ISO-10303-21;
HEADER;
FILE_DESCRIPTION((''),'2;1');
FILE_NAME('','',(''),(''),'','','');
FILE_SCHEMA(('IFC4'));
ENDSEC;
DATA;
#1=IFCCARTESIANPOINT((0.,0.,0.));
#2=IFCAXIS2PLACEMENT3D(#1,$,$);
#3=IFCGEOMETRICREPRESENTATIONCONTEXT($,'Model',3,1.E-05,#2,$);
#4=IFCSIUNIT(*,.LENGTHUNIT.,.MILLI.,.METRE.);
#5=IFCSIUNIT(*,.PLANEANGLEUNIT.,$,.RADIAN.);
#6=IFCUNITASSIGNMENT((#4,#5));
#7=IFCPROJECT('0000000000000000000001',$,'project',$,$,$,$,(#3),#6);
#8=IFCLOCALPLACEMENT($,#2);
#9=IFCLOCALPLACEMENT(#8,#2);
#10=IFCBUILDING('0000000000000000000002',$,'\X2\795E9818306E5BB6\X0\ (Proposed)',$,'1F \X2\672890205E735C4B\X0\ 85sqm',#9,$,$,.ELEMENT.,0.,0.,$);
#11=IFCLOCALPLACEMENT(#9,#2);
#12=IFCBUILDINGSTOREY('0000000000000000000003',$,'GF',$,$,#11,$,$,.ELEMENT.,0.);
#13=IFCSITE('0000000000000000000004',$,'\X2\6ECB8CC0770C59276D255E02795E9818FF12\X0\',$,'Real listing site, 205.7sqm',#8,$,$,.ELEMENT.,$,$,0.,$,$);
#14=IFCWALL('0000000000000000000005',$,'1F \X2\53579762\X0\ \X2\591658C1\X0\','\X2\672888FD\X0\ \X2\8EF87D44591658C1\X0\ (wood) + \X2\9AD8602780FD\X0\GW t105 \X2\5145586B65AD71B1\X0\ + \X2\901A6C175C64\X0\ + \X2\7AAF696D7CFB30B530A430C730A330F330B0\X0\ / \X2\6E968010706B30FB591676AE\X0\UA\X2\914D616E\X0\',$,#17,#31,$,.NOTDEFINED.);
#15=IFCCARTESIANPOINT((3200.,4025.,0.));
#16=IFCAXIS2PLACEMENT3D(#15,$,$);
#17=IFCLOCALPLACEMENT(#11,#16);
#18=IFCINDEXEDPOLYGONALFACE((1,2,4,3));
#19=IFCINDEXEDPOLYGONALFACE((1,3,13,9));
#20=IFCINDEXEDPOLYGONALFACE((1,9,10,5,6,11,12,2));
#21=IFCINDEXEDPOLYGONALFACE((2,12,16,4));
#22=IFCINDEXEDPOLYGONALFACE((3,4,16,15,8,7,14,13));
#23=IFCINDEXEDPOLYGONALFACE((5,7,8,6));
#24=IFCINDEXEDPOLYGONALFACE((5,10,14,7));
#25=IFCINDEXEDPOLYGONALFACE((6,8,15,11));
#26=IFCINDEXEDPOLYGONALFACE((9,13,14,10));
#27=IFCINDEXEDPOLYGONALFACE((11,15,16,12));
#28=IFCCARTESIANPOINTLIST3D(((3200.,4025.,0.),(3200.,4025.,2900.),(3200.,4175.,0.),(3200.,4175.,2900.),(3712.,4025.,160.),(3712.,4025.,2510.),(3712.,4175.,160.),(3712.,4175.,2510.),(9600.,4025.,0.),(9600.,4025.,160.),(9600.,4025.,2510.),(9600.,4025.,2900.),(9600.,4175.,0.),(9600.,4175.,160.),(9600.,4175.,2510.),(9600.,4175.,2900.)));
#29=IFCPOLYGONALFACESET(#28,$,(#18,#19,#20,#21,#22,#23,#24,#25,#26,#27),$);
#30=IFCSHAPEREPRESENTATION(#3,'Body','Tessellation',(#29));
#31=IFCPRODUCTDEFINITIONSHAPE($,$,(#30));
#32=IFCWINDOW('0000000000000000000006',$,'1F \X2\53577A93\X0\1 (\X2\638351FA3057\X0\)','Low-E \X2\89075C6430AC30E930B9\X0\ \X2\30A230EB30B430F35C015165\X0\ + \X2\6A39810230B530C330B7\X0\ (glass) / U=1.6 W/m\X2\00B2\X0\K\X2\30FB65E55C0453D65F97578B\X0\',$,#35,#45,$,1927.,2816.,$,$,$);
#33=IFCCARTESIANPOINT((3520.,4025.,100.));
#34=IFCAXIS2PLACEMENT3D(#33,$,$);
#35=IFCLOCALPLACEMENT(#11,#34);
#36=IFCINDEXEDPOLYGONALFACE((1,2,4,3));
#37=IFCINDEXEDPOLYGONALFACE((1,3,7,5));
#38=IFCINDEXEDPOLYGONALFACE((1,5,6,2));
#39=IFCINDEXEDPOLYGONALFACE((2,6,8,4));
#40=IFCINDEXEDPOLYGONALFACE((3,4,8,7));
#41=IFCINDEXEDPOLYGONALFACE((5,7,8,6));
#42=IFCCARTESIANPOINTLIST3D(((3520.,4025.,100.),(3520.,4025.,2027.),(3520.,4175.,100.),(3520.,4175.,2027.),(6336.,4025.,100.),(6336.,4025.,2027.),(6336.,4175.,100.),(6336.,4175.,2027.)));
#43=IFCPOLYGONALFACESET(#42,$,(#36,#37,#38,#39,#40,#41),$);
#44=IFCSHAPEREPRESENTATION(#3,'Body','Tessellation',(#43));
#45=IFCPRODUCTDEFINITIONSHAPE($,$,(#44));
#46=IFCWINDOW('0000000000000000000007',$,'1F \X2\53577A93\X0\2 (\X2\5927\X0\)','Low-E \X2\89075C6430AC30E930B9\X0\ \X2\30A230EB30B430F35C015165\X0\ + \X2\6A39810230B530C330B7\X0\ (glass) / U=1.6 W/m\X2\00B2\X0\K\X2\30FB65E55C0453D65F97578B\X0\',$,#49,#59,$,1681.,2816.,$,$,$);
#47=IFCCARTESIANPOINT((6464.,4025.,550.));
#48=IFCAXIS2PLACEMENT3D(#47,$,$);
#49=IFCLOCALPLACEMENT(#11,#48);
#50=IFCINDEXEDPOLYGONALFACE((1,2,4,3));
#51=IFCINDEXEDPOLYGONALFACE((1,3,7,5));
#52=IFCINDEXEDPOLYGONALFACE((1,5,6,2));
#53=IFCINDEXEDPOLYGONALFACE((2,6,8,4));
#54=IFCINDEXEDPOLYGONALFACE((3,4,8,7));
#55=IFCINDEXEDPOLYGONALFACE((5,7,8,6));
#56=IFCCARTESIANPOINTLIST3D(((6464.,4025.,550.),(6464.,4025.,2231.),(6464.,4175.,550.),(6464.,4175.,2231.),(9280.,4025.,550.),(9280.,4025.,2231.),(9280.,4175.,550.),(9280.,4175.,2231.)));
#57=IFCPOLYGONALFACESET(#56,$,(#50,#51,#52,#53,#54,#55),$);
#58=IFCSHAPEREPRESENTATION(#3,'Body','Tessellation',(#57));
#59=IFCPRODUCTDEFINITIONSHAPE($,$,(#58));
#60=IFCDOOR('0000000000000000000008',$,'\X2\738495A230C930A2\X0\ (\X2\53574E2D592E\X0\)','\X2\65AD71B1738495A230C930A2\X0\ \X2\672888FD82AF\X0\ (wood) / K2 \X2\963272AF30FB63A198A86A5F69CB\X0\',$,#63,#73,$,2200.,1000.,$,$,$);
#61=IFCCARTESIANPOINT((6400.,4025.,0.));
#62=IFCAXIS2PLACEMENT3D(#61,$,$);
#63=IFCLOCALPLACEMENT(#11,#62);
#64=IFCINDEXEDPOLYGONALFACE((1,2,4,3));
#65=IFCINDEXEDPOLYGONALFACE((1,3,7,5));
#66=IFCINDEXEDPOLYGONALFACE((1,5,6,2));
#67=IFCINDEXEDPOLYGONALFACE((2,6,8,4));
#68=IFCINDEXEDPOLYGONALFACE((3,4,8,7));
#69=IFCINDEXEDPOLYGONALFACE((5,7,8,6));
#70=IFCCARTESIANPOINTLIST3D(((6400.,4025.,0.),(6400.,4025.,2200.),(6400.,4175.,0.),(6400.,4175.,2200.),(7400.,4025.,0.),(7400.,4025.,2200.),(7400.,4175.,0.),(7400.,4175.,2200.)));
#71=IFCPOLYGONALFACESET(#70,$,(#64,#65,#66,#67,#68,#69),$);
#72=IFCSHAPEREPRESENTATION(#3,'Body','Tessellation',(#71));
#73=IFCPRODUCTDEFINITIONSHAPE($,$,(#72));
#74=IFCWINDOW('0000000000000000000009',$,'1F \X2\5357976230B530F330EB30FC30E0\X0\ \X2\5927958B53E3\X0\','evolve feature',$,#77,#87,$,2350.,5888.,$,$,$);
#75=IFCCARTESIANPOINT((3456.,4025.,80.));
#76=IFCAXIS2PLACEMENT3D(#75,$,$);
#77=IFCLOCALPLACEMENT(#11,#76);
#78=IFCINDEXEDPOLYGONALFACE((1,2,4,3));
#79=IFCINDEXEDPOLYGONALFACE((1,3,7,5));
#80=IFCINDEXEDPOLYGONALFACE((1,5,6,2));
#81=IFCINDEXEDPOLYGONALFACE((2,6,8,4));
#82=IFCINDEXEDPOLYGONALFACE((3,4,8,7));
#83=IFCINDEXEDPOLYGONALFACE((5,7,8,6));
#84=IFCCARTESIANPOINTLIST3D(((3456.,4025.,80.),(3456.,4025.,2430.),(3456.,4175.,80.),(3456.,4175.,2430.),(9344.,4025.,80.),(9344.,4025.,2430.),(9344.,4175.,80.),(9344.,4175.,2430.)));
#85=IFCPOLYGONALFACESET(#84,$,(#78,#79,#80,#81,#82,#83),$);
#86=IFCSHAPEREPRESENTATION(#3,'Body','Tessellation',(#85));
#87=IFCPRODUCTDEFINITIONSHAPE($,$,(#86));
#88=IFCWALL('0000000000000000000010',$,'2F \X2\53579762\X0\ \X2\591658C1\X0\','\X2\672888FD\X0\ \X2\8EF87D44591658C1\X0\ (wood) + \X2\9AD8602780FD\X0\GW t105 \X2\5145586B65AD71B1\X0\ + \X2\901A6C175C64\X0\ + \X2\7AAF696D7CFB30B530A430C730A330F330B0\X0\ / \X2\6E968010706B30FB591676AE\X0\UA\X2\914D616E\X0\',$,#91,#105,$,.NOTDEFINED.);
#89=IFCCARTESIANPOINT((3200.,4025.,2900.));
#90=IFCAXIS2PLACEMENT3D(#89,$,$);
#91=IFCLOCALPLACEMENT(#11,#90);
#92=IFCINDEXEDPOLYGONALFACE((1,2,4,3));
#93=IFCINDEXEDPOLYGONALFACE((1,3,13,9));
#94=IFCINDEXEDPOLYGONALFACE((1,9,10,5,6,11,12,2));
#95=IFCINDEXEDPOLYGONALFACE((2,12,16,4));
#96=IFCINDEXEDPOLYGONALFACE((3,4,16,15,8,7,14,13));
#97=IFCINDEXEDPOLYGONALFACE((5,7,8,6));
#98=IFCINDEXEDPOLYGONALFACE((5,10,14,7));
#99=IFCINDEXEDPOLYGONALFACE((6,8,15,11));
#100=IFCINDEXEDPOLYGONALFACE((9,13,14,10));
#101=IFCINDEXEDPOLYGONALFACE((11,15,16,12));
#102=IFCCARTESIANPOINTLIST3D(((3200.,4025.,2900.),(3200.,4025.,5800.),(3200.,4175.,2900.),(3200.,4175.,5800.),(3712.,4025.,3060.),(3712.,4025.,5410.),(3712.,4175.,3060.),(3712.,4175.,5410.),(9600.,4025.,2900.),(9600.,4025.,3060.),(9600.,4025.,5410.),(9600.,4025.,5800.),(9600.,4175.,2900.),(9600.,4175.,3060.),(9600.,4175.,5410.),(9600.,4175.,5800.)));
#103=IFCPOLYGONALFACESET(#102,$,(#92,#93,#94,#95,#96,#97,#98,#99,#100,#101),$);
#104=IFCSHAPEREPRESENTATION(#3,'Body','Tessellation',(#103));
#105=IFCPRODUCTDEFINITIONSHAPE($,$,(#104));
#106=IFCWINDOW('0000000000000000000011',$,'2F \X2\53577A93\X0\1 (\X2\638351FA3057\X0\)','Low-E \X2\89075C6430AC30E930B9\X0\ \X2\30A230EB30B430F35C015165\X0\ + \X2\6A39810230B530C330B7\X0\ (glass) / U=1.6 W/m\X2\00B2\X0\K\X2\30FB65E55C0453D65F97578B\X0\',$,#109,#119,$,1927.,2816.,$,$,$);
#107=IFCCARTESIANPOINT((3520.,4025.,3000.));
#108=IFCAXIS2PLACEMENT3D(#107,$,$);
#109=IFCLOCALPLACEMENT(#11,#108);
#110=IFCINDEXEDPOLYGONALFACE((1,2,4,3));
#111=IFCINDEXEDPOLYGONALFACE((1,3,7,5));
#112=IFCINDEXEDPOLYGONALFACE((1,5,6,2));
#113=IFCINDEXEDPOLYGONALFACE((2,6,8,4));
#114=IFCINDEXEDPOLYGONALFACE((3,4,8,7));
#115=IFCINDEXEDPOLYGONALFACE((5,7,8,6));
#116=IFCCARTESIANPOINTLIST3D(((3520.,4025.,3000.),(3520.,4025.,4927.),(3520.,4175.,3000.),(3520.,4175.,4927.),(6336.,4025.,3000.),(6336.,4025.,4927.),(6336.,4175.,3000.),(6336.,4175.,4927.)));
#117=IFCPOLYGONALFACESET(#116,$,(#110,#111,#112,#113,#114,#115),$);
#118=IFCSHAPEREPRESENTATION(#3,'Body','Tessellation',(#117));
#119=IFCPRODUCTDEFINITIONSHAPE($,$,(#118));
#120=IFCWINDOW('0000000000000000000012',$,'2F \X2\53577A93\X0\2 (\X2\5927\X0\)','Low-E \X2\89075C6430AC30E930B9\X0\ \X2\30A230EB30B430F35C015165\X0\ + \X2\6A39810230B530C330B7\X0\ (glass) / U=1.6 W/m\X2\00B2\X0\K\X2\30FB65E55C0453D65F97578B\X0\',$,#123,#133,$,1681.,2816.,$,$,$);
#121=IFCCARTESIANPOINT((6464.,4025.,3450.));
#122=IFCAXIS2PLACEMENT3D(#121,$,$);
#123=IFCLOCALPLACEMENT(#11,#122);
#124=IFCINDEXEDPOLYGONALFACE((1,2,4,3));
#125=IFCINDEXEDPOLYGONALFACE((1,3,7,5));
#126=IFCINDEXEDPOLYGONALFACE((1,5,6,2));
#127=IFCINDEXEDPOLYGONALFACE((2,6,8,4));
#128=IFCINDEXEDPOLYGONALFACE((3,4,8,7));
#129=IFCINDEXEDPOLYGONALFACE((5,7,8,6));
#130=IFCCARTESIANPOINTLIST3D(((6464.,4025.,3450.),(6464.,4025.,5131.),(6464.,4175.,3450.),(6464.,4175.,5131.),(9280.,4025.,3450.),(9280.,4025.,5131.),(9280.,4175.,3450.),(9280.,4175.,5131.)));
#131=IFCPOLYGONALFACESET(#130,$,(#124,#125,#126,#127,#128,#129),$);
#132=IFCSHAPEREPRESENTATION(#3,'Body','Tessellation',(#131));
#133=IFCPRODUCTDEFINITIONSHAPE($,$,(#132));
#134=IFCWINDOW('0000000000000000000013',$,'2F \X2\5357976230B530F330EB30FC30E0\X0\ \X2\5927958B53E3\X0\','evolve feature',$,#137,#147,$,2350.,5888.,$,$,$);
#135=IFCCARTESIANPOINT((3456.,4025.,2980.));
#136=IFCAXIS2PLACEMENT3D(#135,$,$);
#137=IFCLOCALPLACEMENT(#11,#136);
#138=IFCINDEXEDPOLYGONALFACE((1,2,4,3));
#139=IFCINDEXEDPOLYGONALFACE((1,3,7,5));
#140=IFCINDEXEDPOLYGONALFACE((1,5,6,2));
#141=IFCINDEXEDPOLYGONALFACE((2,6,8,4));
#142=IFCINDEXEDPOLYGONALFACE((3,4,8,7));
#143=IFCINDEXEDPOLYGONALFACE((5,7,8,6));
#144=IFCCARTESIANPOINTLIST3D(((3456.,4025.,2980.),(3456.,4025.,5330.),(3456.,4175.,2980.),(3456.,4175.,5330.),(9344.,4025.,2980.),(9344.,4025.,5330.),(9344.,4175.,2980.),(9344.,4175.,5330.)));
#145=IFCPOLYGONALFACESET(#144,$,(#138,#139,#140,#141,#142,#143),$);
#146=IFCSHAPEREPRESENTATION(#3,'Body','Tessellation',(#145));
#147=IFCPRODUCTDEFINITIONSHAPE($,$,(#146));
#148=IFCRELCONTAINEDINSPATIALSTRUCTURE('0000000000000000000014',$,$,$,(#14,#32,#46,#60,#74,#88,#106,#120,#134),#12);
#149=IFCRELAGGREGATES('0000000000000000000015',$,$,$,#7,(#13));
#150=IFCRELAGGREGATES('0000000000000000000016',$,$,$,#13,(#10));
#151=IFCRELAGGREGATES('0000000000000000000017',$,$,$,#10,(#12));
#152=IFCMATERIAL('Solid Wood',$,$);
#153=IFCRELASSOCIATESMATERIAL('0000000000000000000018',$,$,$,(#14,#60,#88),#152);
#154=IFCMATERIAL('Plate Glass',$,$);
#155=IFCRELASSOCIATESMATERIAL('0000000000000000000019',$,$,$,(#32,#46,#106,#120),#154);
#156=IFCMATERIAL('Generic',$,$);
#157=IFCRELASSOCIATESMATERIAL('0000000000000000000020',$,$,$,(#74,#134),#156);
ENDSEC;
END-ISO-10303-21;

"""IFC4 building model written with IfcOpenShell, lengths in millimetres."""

from ifc_helpers import new_model, si_unit, frame, frame_2d, origin, place, context, project, spatial, rectangle, extrude, material, element, fill, save


model = new_model("IFC4")

# Units and contexts
model_context = context("Model", 3, precision=1e-05, world=origin())
ifc_project = project(units=[si_unit("LENGTHUNIT", "METRE", prefix="MILLI"), si_unit("PLANEANGLEUNIT", "RADIAN")], contexts=[model_context])

# Site, building, storey
site_placement = place(None, origin())
site = spatial("IfcSite", under=ifc_project, at=site_placement, Name="滋賀県大津市神領２", ObjectType="Real listing site, 205.7sqm", CompositionType="ELEMENT", RefElevation=0.0)
building_placement = place(site_placement, origin())
building = spatial("IfcBuilding", under=site, at=building_placement, Name="神領の家 (Proposed)", ObjectType="1F 木造平屋 85sqm", CompositionType="ELEMENT", ElevationOfRefHeight=0.0, ElevationOfTerrain=0.0)
storey_placement = place(building_placement, origin())
storey = spatial("IfcBuildingStorey", under=building, at=storey_placement, Name="GF", CompositionType="ELEMENT", Elevation=0.0)

# Shared definitions
ifc_material_1 = material(Name="Solid Wood")
ifc_material_2 = material(Name="Generic")

# Wall, openings, windows, door
wall_1_placement = place(storey_placement, frame((3200.0, 4025.0, 0.0)))
wall_1 = element("IfcWall", 1, at=wall_1_placement, inside=storey, material=ifc_material_1, Name="1F 南面 外壁", Description="木製 軸組外壁 (wood) + 高性能GW t105 充填断熱 + 通気層 + 窯業系サイディング / 準耐火・外皮UA配慮", PredefinedType="NOTDEFINED", context=model_context, shape_type="SweptSolid", body=[
    extrude(rectangle(XDim=6400.0, YDim=150.0, at=frame_2d((3200.0, 75.0))), frame((3200.0, 4025.0, 0.0)), (0.0, 0.0, 1.0), 2900.0),
])
opening_1_placement = place(storey_placement, frame((3520.0, 4025.0, 100.0)))
opening_1 = element("IfcOpeningElement", 2, at=opening_1_placement, cuts=wall_1, PredefinedType="NOTDEFINED", context=model_context, shape_type="SweptSolid", body=[
    extrude(rectangle(XDim=2816.0, YDim=150.0, at=frame_2d((1408.0, 75.0))), frame((3520.0, 4025.0, 100.0)), (0.0, 0.0, 1.0), 1927.0),
])
opening_2_placement = place(storey_placement, frame((6464.0, 4025.0, 550.0)))
opening_2 = element("IfcOpeningElement", 3, at=opening_2_placement, cuts=wall_1, PredefinedType="NOTDEFINED", context=model_context, shape_type="SweptSolid", body=[
    extrude(rectangle(XDim=2816.0, YDim=150.0, at=frame_2d((1408.0, 75.0))), frame((6464.0, 4025.0, 550.0)), (0.0, 0.0, 1.0), 1681.0),
])
opening_3_placement = place(storey_placement, frame((6400.0, 4025.0, 0.0)))
opening_3 = element("IfcOpeningElement", 4, at=opening_3_placement, cuts=wall_1, PredefinedType="NOTDEFINED", context=model_context, shape_type="SweptSolid", body=[
    extrude(rectangle(XDim=1000.0, YDim=150.0, at=frame_2d((500.0, 75.0))), frame((6400.0, 4025.0, 0.0)), (0.0, 0.0, 1.0), 2200.0),
])
opening_4_placement = place(storey_placement, frame((3456.0, 4025.0, 80.0)))
opening_4 = element("IfcOpeningElement", 5, at=opening_4_placement, cuts=wall_1, PredefinedType="NOTDEFINED", context=model_context, shape_type="SweptSolid", body=[
    extrude(rectangle(XDim=5888.0, YDim=150.0, at=frame_2d((2944.0, 75.0))), frame((3456.0, 4025.0, 80.0)), (0.0, 0.0, 1.0), 2350.0),
])
ifc_material_3 = material(Name="Plate Glass")
window_1_placement = place(storey_placement, frame((3520.0, 4025.0, 100.0)))
window_1 = element("IfcWindow", 6, at=window_1_placement, inside=storey, material=ifc_material_3, Name="1F 南窓1 (掃出し)", Description="Low-E 複層ガラス アルゴン封入 + 樹脂サッシ (glass) / U=1.6 W/m²K・日射取得型", OverallHeight=1927.0, OverallWidth=2816.0, context=model_context, shape_type="SweptSolid", body=[
    extrude(rectangle(XDim=2816.0, YDim=150.0, at=frame_2d((1408.0, 75.0))), frame((3520.0, 4025.0, 100.0)), (0.0, 0.0, 1.0), 1927.0),
])
fill(opening_1, window_1)
window_2_placement = place(storey_placement, frame((6464.0, 4025.0, 550.0)))
window_2 = element("IfcWindow", 7, at=window_2_placement, inside=storey, material=ifc_material_3, Name="1F 南窓2 (大)", Description="Low-E 複層ガラス アルゴン封入 + 樹脂サッシ (glass) / U=1.6 W/m²K・日射取得型", OverallHeight=1681.0, OverallWidth=2816.0, context=model_context, shape_type="SweptSolid", body=[
    extrude(rectangle(XDim=2816.0, YDim=150.0, at=frame_2d((1408.0, 75.0))), frame((6464.0, 4025.0, 550.0)), (0.0, 0.0, 1.0), 1681.0),
])
fill(opening_2, window_2)
door_placement = place(storey_placement, frame((6400.0, 4025.0, 0.0)))
door = element("IfcDoor", 8, at=door_placement, inside=storey, material=ifc_material_1, Name="玄関ドア (南中央)", Description="断熱玄関ドア 木製芯 (wood) / K2 防犯・採風機構", OverallHeight=2200.0, OverallWidth=1000.0, context=model_context, shape_type="SweptSolid", body=[
    extrude(rectangle(XDim=1000.0, YDim=150.0, at=frame_2d((500.0, 75.0))), frame((6400.0, 4025.0, 0.0)), (0.0, 0.0, 1.0), 2200.0),
])
fill(opening_3, door)
window_3_placement = place(storey_placement, frame((3456.0, 4025.0, 80.0)))
window_3 = element("IfcWindow", 9, at=window_3_placement, inside=storey, material=ifc_material_2, Name="1F 南面サンルーム 大開口", Description="evolve feature", OverallHeight=2350.0, OverallWidth=5888.0, context=model_context, shape_type="SweptSolid", body=[
    extrude(rectangle(XDim=5888.0, YDim=150.0, at=frame_2d((2944.0, 75.0))), frame((3456.0, 4025.0, 80.0)), (0.0, 0.0, 1.0), 2350.0),
])
fill(opening_4, window_3)

# Wall, openings, windows
wall_2_placement = place(storey_placement, frame((3200.0, 4025.0, 2900.0)))
wall_2 = element("IfcWall", 10, at=wall_2_placement, inside=storey, material=ifc_material_1, Name="2F 南面 外壁", Description="木製 軸組外壁 (wood) + 高性能GW t105 充填断熱 + 通気層 + 窯業系サイディング / 準耐火・外皮UA配慮", PredefinedType="NOTDEFINED", context=model_context, shape_type="SweptSolid", body=[
    extrude(rectangle(XDim=6400.0, YDim=150.0, at=frame_2d((3200.0, 75.0))), frame((3200.0, 4025.0, 2900.0)), (0.0, 0.0, 1.0), 2900.0),
])
opening_5_placement = place(storey_placement, frame((3520.0, 4025.0, 3000.0)))
opening_5 = element("IfcOpeningElement", 11, at=opening_5_placement, cuts=wall_2, PredefinedType="NOTDEFINED", context=model_context, shape_type="SweptSolid", body=[
    extrude(rectangle(XDim=2816.0, YDim=150.0, at=frame_2d((1408.0, 75.0))), frame((3520.0, 4025.0, 3000.0)), (0.0, 0.0, 1.0), 1927.0),
])
opening_6_placement = place(storey_placement, frame((6464.0, 4025.0, 3450.0)))
opening_6 = element("IfcOpeningElement", 12, at=opening_6_placement, cuts=wall_2, PredefinedType="NOTDEFINED", context=model_context, shape_type="SweptSolid", body=[
    extrude(rectangle(XDim=2816.0, YDim=150.0, at=frame_2d((1408.0, 75.0))), frame((6464.0, 4025.0, 3450.0)), (0.0, 0.0, 1.0), 1681.0),
])
opening_7_placement = place(storey_placement, frame((3456.0, 4025.0, 2980.0)))
opening_7 = element("IfcOpeningElement", 13, at=opening_7_placement, cuts=wall_2, PredefinedType="NOTDEFINED", context=model_context, shape_type="SweptSolid", body=[
    extrude(rectangle(XDim=5888.0, YDim=150.0, at=frame_2d((2944.0, 75.0))), frame((3456.0, 4025.0, 2980.0)), (0.0, 0.0, 1.0), 2350.0),
])
window_4_placement = place(storey_placement, frame((3520.0, 4025.0, 3000.0)))
window_4 = element("IfcWindow", 14, at=window_4_placement, inside=storey, material=ifc_material_3, Name="2F 南窓1 (掃出し)", Description="Low-E 複層ガラス アルゴン封入 + 樹脂サッシ (glass) / U=1.6 W/m²K・日射取得型", OverallHeight=1927.0, OverallWidth=2816.0, context=model_context, shape_type="SweptSolid", body=[
    extrude(rectangle(XDim=2816.0, YDim=150.0, at=frame_2d((1408.0, 75.0))), frame((3520.0, 4025.0, 3000.0)), (0.0, 0.0, 1.0), 1927.0),
])
fill(opening_5, window_4)
window_5_placement = place(storey_placement, frame((6464.0, 4025.0, 3450.0)))
window_5 = element("IfcWindow", 15, at=window_5_placement, inside=storey, material=ifc_material_3, Name="2F 南窓2 (大)", Description="Low-E 複層ガラス アルゴン封入 + 樹脂サッシ (glass) / U=1.6 W/m²K・日射取得型", OverallHeight=1681.0, OverallWidth=2816.0, context=model_context, shape_type="SweptSolid", body=[
    extrude(rectangle(XDim=2816.0, YDim=150.0, at=frame_2d((1408.0, 75.0))), frame((6464.0, 4025.0, 3450.0)), (0.0, 0.0, 1.0), 1681.0),
])
fill(opening_6, window_5)
window_6_placement = place(storey_placement, frame((3456.0, 4025.0, 2980.0)))
window_6 = element("IfcWindow", 16, at=window_6_placement, inside=storey, material=ifc_material_2, Name="2F 南面サンルーム 大開口", Description="evolve feature", OverallHeight=2350.0, OverallWidth=5888.0, context=model_context, shape_type="SweptSolid", body=[
    extrude(rectangle(XDim=5888.0, YDim=150.0, at=frame_2d((2944.0, 75.0))), frame((3456.0, 4025.0, 2980.0)), (0.0, 0.0, 1.0), 2350.0),
])
fill(opening_7, window_6)

save(model, "model.ifc")
